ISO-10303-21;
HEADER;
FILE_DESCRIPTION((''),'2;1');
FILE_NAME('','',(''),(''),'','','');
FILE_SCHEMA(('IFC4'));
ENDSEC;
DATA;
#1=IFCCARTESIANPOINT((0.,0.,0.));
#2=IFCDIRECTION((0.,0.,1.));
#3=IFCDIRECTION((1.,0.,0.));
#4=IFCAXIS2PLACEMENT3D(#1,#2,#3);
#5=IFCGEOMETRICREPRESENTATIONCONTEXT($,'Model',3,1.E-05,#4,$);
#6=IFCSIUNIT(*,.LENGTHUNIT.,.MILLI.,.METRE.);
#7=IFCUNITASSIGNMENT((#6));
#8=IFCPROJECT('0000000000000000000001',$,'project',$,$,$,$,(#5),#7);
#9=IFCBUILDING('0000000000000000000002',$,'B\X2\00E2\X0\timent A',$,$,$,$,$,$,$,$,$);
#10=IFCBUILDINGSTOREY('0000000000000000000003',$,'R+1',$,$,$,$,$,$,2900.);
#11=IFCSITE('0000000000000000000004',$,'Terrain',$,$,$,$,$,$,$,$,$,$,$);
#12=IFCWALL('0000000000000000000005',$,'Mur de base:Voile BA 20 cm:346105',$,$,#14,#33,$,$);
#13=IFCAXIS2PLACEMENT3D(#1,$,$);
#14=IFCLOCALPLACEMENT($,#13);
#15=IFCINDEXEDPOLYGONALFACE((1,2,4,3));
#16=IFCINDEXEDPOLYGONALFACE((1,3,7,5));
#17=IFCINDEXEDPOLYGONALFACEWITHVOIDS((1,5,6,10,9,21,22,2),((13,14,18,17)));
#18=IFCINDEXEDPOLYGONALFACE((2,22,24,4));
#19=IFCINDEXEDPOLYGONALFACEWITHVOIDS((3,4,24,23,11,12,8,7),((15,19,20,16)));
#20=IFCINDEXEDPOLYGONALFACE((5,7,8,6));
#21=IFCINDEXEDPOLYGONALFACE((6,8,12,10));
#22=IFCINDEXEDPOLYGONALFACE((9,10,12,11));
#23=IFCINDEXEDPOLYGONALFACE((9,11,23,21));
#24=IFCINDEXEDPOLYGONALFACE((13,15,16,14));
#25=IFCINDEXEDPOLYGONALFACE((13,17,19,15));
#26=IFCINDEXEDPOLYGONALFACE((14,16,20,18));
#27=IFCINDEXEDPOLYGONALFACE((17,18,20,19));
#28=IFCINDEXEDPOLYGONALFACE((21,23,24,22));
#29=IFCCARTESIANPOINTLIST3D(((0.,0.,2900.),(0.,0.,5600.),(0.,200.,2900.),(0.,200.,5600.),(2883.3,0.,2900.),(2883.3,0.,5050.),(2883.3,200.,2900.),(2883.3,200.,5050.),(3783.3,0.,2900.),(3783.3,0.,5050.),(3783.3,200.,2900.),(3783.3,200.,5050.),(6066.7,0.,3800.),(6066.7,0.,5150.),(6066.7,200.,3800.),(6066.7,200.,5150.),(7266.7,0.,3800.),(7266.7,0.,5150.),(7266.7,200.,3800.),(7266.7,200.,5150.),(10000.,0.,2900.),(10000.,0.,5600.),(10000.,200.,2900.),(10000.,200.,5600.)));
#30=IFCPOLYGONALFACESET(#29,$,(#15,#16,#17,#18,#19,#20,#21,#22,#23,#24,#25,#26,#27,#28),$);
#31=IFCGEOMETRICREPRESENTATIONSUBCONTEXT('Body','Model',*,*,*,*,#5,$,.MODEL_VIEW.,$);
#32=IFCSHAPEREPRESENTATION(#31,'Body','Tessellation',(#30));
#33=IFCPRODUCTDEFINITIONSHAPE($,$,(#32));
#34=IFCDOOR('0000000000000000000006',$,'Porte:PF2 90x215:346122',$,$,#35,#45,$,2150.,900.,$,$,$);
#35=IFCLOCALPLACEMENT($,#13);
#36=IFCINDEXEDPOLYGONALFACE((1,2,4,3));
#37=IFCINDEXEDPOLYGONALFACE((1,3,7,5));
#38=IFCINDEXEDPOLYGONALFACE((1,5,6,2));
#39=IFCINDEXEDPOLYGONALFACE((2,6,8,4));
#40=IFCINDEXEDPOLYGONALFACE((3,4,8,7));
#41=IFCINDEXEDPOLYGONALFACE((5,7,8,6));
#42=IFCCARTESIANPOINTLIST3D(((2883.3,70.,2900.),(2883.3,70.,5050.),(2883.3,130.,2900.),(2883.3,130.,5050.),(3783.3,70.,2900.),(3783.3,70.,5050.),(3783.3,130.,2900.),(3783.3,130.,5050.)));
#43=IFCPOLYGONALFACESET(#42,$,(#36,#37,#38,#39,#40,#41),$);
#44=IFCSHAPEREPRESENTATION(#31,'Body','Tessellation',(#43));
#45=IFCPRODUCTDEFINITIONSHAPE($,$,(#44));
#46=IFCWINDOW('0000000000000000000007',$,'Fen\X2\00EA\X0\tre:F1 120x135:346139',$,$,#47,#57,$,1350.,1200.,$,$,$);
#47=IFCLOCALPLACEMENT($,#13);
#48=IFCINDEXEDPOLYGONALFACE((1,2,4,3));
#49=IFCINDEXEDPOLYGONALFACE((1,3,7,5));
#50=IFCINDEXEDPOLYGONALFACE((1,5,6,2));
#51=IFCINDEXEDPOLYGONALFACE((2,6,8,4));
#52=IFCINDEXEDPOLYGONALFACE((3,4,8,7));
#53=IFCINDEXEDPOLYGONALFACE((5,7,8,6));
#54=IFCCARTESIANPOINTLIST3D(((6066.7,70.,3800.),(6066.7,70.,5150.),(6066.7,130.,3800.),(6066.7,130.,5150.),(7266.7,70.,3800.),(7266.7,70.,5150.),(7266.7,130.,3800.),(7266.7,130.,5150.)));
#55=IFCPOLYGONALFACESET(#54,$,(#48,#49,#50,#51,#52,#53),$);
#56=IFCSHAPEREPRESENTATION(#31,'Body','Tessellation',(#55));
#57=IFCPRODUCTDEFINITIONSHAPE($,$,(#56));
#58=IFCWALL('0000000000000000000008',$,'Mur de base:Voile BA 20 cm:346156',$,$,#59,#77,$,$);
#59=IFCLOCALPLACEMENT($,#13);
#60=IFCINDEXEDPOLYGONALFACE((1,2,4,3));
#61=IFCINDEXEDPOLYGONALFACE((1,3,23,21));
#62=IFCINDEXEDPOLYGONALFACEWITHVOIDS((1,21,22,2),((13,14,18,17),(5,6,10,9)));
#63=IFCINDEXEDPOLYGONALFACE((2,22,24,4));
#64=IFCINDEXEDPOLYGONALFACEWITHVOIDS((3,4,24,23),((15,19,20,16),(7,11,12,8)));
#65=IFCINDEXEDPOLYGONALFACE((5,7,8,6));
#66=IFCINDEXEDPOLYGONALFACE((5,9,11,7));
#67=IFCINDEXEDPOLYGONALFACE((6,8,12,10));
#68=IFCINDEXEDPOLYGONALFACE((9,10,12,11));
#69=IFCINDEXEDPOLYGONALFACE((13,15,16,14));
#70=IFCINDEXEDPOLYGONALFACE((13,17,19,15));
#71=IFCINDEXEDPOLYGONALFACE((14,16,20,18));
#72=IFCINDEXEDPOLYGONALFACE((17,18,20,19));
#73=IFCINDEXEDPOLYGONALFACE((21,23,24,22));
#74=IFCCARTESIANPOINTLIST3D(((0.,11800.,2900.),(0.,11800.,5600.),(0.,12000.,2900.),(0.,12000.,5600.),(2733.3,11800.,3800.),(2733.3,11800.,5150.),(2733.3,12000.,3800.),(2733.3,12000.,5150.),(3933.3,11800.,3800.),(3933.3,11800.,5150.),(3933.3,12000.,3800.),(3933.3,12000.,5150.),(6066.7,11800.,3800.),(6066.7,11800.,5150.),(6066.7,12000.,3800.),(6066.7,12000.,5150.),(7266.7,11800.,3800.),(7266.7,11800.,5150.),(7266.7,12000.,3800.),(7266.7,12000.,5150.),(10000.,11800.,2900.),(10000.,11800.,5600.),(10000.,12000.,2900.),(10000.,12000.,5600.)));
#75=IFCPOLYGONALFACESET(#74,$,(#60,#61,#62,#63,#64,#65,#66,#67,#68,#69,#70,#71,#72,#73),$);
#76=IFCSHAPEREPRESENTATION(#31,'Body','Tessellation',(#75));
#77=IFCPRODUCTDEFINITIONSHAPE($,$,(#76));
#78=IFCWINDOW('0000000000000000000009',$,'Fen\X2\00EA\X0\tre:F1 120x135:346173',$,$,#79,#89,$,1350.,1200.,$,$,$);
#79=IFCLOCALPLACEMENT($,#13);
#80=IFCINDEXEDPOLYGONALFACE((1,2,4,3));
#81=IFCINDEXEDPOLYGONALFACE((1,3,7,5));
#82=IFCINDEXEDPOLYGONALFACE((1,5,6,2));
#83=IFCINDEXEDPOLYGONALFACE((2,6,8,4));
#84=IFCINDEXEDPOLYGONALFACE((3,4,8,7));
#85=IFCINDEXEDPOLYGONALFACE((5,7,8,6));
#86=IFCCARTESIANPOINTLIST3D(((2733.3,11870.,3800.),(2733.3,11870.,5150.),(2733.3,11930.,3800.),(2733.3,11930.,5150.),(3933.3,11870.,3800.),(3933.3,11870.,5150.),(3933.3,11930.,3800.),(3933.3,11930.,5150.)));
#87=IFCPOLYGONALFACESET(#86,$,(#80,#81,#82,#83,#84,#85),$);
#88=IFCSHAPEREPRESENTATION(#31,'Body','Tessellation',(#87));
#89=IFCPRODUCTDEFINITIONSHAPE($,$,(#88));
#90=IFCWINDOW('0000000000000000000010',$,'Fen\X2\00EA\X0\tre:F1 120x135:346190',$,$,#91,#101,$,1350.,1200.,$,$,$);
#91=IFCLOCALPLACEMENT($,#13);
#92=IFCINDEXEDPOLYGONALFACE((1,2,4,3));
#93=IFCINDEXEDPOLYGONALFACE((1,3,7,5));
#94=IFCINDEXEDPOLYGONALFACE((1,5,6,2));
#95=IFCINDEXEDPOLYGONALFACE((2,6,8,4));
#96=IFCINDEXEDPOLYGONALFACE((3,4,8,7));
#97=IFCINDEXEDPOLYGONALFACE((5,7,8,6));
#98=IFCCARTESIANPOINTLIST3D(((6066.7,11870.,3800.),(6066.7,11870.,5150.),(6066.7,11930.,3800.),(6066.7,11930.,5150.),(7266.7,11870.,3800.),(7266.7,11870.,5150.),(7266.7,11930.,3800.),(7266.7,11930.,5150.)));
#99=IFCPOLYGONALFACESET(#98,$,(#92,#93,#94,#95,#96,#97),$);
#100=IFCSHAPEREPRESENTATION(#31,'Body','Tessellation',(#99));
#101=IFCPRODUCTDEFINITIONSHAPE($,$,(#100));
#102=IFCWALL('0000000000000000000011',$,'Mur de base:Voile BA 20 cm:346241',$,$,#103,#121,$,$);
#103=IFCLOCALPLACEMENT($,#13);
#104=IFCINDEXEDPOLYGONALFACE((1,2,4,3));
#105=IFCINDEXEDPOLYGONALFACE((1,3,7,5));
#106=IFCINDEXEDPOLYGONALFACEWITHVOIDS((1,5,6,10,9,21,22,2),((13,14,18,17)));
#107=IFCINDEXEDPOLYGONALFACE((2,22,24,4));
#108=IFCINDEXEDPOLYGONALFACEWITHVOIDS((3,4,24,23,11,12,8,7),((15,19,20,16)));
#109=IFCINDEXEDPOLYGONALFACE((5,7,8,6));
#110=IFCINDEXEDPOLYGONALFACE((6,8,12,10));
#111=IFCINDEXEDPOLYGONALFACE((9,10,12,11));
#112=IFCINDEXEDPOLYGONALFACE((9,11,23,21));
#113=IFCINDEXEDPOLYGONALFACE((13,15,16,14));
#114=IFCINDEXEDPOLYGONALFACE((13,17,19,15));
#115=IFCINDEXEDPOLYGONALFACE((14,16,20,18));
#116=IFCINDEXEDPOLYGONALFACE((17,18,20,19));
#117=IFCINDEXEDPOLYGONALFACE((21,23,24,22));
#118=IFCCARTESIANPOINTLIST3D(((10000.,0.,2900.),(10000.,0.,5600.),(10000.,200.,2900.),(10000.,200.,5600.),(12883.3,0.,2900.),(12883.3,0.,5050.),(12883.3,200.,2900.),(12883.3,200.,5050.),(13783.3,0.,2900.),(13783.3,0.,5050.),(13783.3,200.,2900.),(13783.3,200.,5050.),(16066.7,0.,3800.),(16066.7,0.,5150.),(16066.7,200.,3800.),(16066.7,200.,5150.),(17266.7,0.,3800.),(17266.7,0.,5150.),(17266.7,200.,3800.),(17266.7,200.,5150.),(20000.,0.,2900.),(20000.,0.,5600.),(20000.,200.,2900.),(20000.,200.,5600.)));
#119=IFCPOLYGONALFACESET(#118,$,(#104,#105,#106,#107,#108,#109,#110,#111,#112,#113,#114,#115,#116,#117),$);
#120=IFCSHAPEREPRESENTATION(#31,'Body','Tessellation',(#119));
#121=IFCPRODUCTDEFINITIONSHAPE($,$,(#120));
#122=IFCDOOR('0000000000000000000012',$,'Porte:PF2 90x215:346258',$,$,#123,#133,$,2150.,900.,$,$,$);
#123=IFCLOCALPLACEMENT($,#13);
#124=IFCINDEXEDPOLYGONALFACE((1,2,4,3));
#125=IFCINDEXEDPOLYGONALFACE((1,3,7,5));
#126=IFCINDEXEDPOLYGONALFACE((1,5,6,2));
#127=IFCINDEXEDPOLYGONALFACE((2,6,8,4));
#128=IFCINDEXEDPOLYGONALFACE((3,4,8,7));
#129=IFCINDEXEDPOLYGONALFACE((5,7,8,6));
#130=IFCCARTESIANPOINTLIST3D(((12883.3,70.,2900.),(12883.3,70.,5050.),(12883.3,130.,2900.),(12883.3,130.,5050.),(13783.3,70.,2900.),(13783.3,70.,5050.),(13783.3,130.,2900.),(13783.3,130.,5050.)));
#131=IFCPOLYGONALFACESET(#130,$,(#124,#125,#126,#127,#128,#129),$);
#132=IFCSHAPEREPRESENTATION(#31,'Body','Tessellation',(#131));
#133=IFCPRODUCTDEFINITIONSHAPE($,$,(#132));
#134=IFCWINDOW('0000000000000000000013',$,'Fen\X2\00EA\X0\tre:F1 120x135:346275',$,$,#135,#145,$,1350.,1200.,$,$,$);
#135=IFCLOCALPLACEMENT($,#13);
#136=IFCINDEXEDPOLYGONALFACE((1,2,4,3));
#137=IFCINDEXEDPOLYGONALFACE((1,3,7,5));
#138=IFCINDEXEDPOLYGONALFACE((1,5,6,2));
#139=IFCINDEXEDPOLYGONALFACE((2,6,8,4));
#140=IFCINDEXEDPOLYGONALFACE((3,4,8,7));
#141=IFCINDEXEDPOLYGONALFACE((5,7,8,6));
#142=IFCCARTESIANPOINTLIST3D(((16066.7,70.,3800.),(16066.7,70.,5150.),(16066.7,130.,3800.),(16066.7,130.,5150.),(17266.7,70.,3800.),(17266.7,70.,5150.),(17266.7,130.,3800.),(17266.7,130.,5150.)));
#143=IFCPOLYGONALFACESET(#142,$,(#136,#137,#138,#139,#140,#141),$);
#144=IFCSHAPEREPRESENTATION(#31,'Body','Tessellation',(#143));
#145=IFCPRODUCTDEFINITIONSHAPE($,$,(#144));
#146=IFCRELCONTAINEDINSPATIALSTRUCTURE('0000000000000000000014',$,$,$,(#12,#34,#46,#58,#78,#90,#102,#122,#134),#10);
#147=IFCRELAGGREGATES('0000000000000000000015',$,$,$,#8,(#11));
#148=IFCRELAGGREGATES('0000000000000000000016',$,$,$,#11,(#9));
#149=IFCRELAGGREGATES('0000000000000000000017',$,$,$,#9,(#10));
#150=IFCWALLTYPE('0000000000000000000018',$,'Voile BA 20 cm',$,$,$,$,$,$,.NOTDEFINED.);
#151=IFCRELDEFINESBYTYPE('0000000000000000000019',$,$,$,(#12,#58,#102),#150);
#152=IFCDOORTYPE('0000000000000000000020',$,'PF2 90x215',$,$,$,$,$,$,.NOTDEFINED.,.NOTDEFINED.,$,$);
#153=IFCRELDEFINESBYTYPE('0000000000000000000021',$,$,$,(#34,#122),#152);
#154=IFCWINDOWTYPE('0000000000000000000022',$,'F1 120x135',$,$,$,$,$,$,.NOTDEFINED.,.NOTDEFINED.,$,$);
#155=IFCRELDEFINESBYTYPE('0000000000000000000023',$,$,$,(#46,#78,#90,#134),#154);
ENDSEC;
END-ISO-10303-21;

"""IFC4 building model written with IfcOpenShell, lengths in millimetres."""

from ifc_helpers import new_model, si_unit, frame, frame_2d, origin_with_axes, place, context, subcontext, project, spatial, rectangle, extrude, type_object, element, fill, save


model = new_model("IFC4")

# Units and contexts
model_context = context("Model", 3, precision=1e-05, world=origin_with_axes())
body_context = subcontext(model_context, "Body", "Model", "MODEL_VIEW")
ifc_project = project(units=[si_unit("LENGTHUNIT", "METRE", prefix="MILLI")], contexts=[model_context])

# Site, building, storey
site = spatial("IfcSite", under=ifc_project, Name="Terrain")
building = spatial("IfcBuilding", under=site, Name="Bâtiment A")
storey = spatial("IfcBuildingStorey", under=building, Name="R+1", Elevation=2900.0)

# Wall, openings, door, window
wall_type_1 = type_object("IfcWallType", Name="Voile BA 20 cm", PredefinedType="NOTDEFINED")
wall_1_placement = place(None, origin_with_axes())
wall_1 = element("IfcWall", 1, at=wall_1_placement, inside=storey, type_object=wall_type_1, Name="Mur de base:Voile BA 20 cm:346105", context=body_context, shape_type="SweptSolid", body=[
    extrude(rectangle(XDim=10000.0, YDim=200.0, at=frame_2d((5000.0, 100.0))), frame((0.0, 0.0, 2900.0), z_axis=(0.0, 0.0, 1.0), x_axis=(1.0, 0.0, 0.0)), (0.0, 0.0, 1.0), 2700.0),
])
opening_1_placement = place(None, origin_with_axes())
opening_1 = element("IfcOpeningElement", 2, at=opening_1_placement, cuts=wall_1, context=body_context, shape_type="SweptSolid", body=[
    extrude(rectangle(XDim=900.0, YDim=320.0, at=frame_2d((3333.3, 100.0))), frame((0.0, 0.0, 2900.0), z_axis=(0.0, 0.0, 1.0), x_axis=(1.0, 0.0, 0.0)), (0.0, 0.0, 1.0), 2150.0),
])
opening_2_placement = place(None, origin_with_axes())
opening_2 = element("IfcOpeningElement", 3, at=opening_2_placement, cuts=wall_1, context=body_context, shape_type="SweptSolid", body=[
    extrude(rectangle(XDim=1200.0, YDim=320.0, at=frame_2d((6666.7, 100.0))), frame((0.0, 0.0, 3800.0), z_axis=(0.0, 0.0, 1.0), x_axis=(1.0, 0.0, 0.0)), (0.0, 0.0, 1.0), 1350.0),
])
door_type = type_object("IfcDoorType", Name="PF2 90x215", OperationType="NOTDEFINED", PredefinedType="NOTDEFINED")
door_1_placement = place(None, origin_with_axes())
door_1 = element("IfcDoor", 4, at=door_1_placement, inside=storey, type_object=door_type, Name="Porte:PF2 90x215:346122", OverallHeight=2150.0, OverallWidth=900.0, context=body_context, shape_type="SweptSolid", body=[
    extrude(rectangle(XDim=900.0, YDim=60.0, at=frame_2d((3333.3, 100.0))), frame((0.0, 0.0, 2900.0), z_axis=(0.0, 0.0, 1.0), x_axis=(1.0, 0.0, 0.0)), (0.0, 0.0, 1.0), 2150.0),
])
fill(opening_1, door_1)
window_type = type_object("IfcWindowType", Name="F1 120x135", PartitioningType="NOTDEFINED", PredefinedType="NOTDEFINED")
window_1_placement = place(None, origin_with_axes())
window_1 = element("IfcWindow", 5, at=window_1_placement, inside=storey, type_object=window_type, Name="Fenêtre:F1 120x135:346139", OverallHeight=1350.0, OverallWidth=1200.0, context=body_context, shape_type="SweptSolid", body=[
    extrude(rectangle(XDim=1200.0, YDim=60.0, at=frame_2d((6666.7, 100.0))), frame((0.0, 0.0, 3800.0), z_axis=(0.0, 0.0, 1.0), x_axis=(1.0, 0.0, 0.0)), (0.0, 0.0, 1.0), 1350.0),
])
fill(opening_2, window_1)

# Wall, openings, windows
wall_2_placement = place(None, origin_with_axes())
wall_2 = element("IfcWall", 6, at=wall_2_placement, inside=storey, type_object=wall_type_1, Name="Mur de base:Voile BA 20 cm:346156", context=body_context, shape_type="SweptSolid", body=[
    extrude(rectangle(XDim=10000.0, YDim=200.0, at=frame_2d((5000.0, 11900.0))), frame((0.0, 0.0, 2900.0), z_axis=(0.0, 0.0, 1.0), x_axis=(1.0, 0.0, 0.0)), (0.0, 0.0, 1.0), 2700.0),
])
opening_3_placement = place(None, origin_with_axes())
opening_3 = element("IfcOpeningElement", 7, at=opening_3_placement, cuts=wall_2, context=body_context, shape_type="SweptSolid", body=[
    extrude(rectangle(XDim=1200.0, YDim=320.0, at=frame_2d((3333.3, 11900.0))), frame((0.0, 0.0, 3800.0), z_axis=(0.0, 0.0, 1.0), x_axis=(1.0, 0.0, 0.0)), (0.0, 0.0, 1.0), 1350.0),
])
opening_4_placement = place(None, origin_with_axes())
opening_4 = element("IfcOpeningElement", 8, at=opening_4_placement, cuts=wall_2, context=body_context, shape_type="SweptSolid", body=[
    extrude(rectangle(XDim=1200.0, YDim=320.0, at=frame_2d((6666.7, 11900.0))), frame((0.0, 0.0, 3800.0), z_axis=(0.0, 0.0, 1.0), x_axis=(1.0, 0.0, 0.0)), (0.0, 0.0, 1.0), 1350.0),
])
window_2_placement = place(None, origin_with_axes())
window_2 = element("IfcWindow", 9, at=window_2_placement, inside=storey, type_object=window_type, Name="Fenêtre:F1 120x135:346173", OverallHeight=1350.0, OverallWidth=1200.0, context=body_context, shape_type="SweptSolid", body=[
    extrude(rectangle(XDim=1200.0, YDim=60.0, at=frame_2d((3333.3, 11900.0))), frame((0.0, 0.0, 3800.0), z_axis=(0.0, 0.0, 1.0), x_axis=(1.0, 0.0, 0.0)), (0.0, 0.0, 1.0), 1350.0),
])
fill(opening_3, window_2)
window_3_placement = place(None, origin_with_axes())
window_3 = element("IfcWindow", 10, at=window_3_placement, inside=storey, type_object=window_type, Name="Fenêtre:F1 120x135:346190", OverallHeight=1350.0, OverallWidth=1200.0, context=body_context, shape_type="SweptSolid", body=[
    extrude(rectangle(XDim=1200.0, YDim=60.0, at=frame_2d((6666.7, 11900.0))), frame((0.0, 0.0, 3800.0), z_axis=(0.0, 0.0, 1.0), x_axis=(1.0, 0.0, 0.0)), (0.0, 0.0, 1.0), 1350.0),
])
fill(opening_4, window_3)

# Wall, openings, door, window
wall_3_placement = place(None, origin_with_axes())
wall_3 = element("IfcWall", 11, at=wall_3_placement, inside=storey, type_object=wall_type_1, Name="Mur de base:Voile BA 20 cm:346241", context=body_context, shape_type="SweptSolid", body=[
    extrude(rectangle(XDim=10000.0, YDim=200.0, at=frame_2d((15000.0, 100.0))), frame((0.0, 0.0, 2900.0), z_axis=(0.0, 0.0, 1.0), x_axis=(1.0, 0.0, 0.0)), (0.0, 0.0, 1.0), 2700.0),
])
opening_5_placement = place(None, origin_with_axes())
opening_5 = element("IfcOpeningElement", 12, at=opening_5_placement, cuts=wall_3, context=body_context, shape_type="SweptSolid", body=[
    extrude(rectangle(XDim=900.0, YDim=320.0, at=frame_2d((13333.3, 100.0))), frame((0.0, 0.0, 2900.0), z_axis=(0.0, 0.0, 1.0), x_axis=(1.0, 0.0, 0.0)), (0.0, 0.0, 1.0), 2150.0),
])
opening_6_placement = place(None, origin_with_axes())
opening_6 = element("IfcOpeningElement", 13, at=opening_6_placement, cuts=wall_3, context=body_context, shape_type="SweptSolid", body=[
    extrude(rectangle(XDim=1200.0, YDim=320.0, at=frame_2d((16666.7, 100.0))), frame((0.0, 0.0, 3800.0), z_axis=(0.0, 0.0, 1.0), x_axis=(1.0, 0.0, 0.0)), (0.0, 0.0, 1.0), 1350.0),
])
door_2_placement = place(None, origin_with_axes())
door_2 = element("IfcDoor", 14, at=door_2_placement, inside=storey, type_object=door_type, Name="Porte:PF2 90x215:346258", OverallHeight=2150.0, OverallWidth=900.0, context=body_context, shape_type="SweptSolid", body=[
    extrude(rectangle(XDim=900.0, YDim=60.0, at=frame_2d((13333.3, 100.0))), frame((0.0, 0.0, 2900.0), z_axis=(0.0, 0.0, 1.0), x_axis=(1.0, 0.0, 0.0)), (0.0, 0.0, 1.0), 2150.0),
])
fill(opening_5, door_2)
window_4_placement = place(None, origin_with_axes())
window_4 = element("IfcWindow", 15, at=window_4_placement, inside=storey, type_object=window_type, Name="Fenêtre:F1 120x135:346275", OverallHeight=1350.0, OverallWidth=1200.0, context=body_context, shape_type="SweptSolid", body=[
    extrude(rectangle(XDim=1200.0, YDim=60.0, at=frame_2d((16666.7, 100.0))), frame((0.0, 0.0, 3800.0), z_axis=(0.0, 0.0, 1.0), x_axis=(1.0, 0.0, 0.0)), (0.0, 0.0, 1.0), 1350.0),
])
fill(opening_6, window_4)

save(model, "model.ifc")
